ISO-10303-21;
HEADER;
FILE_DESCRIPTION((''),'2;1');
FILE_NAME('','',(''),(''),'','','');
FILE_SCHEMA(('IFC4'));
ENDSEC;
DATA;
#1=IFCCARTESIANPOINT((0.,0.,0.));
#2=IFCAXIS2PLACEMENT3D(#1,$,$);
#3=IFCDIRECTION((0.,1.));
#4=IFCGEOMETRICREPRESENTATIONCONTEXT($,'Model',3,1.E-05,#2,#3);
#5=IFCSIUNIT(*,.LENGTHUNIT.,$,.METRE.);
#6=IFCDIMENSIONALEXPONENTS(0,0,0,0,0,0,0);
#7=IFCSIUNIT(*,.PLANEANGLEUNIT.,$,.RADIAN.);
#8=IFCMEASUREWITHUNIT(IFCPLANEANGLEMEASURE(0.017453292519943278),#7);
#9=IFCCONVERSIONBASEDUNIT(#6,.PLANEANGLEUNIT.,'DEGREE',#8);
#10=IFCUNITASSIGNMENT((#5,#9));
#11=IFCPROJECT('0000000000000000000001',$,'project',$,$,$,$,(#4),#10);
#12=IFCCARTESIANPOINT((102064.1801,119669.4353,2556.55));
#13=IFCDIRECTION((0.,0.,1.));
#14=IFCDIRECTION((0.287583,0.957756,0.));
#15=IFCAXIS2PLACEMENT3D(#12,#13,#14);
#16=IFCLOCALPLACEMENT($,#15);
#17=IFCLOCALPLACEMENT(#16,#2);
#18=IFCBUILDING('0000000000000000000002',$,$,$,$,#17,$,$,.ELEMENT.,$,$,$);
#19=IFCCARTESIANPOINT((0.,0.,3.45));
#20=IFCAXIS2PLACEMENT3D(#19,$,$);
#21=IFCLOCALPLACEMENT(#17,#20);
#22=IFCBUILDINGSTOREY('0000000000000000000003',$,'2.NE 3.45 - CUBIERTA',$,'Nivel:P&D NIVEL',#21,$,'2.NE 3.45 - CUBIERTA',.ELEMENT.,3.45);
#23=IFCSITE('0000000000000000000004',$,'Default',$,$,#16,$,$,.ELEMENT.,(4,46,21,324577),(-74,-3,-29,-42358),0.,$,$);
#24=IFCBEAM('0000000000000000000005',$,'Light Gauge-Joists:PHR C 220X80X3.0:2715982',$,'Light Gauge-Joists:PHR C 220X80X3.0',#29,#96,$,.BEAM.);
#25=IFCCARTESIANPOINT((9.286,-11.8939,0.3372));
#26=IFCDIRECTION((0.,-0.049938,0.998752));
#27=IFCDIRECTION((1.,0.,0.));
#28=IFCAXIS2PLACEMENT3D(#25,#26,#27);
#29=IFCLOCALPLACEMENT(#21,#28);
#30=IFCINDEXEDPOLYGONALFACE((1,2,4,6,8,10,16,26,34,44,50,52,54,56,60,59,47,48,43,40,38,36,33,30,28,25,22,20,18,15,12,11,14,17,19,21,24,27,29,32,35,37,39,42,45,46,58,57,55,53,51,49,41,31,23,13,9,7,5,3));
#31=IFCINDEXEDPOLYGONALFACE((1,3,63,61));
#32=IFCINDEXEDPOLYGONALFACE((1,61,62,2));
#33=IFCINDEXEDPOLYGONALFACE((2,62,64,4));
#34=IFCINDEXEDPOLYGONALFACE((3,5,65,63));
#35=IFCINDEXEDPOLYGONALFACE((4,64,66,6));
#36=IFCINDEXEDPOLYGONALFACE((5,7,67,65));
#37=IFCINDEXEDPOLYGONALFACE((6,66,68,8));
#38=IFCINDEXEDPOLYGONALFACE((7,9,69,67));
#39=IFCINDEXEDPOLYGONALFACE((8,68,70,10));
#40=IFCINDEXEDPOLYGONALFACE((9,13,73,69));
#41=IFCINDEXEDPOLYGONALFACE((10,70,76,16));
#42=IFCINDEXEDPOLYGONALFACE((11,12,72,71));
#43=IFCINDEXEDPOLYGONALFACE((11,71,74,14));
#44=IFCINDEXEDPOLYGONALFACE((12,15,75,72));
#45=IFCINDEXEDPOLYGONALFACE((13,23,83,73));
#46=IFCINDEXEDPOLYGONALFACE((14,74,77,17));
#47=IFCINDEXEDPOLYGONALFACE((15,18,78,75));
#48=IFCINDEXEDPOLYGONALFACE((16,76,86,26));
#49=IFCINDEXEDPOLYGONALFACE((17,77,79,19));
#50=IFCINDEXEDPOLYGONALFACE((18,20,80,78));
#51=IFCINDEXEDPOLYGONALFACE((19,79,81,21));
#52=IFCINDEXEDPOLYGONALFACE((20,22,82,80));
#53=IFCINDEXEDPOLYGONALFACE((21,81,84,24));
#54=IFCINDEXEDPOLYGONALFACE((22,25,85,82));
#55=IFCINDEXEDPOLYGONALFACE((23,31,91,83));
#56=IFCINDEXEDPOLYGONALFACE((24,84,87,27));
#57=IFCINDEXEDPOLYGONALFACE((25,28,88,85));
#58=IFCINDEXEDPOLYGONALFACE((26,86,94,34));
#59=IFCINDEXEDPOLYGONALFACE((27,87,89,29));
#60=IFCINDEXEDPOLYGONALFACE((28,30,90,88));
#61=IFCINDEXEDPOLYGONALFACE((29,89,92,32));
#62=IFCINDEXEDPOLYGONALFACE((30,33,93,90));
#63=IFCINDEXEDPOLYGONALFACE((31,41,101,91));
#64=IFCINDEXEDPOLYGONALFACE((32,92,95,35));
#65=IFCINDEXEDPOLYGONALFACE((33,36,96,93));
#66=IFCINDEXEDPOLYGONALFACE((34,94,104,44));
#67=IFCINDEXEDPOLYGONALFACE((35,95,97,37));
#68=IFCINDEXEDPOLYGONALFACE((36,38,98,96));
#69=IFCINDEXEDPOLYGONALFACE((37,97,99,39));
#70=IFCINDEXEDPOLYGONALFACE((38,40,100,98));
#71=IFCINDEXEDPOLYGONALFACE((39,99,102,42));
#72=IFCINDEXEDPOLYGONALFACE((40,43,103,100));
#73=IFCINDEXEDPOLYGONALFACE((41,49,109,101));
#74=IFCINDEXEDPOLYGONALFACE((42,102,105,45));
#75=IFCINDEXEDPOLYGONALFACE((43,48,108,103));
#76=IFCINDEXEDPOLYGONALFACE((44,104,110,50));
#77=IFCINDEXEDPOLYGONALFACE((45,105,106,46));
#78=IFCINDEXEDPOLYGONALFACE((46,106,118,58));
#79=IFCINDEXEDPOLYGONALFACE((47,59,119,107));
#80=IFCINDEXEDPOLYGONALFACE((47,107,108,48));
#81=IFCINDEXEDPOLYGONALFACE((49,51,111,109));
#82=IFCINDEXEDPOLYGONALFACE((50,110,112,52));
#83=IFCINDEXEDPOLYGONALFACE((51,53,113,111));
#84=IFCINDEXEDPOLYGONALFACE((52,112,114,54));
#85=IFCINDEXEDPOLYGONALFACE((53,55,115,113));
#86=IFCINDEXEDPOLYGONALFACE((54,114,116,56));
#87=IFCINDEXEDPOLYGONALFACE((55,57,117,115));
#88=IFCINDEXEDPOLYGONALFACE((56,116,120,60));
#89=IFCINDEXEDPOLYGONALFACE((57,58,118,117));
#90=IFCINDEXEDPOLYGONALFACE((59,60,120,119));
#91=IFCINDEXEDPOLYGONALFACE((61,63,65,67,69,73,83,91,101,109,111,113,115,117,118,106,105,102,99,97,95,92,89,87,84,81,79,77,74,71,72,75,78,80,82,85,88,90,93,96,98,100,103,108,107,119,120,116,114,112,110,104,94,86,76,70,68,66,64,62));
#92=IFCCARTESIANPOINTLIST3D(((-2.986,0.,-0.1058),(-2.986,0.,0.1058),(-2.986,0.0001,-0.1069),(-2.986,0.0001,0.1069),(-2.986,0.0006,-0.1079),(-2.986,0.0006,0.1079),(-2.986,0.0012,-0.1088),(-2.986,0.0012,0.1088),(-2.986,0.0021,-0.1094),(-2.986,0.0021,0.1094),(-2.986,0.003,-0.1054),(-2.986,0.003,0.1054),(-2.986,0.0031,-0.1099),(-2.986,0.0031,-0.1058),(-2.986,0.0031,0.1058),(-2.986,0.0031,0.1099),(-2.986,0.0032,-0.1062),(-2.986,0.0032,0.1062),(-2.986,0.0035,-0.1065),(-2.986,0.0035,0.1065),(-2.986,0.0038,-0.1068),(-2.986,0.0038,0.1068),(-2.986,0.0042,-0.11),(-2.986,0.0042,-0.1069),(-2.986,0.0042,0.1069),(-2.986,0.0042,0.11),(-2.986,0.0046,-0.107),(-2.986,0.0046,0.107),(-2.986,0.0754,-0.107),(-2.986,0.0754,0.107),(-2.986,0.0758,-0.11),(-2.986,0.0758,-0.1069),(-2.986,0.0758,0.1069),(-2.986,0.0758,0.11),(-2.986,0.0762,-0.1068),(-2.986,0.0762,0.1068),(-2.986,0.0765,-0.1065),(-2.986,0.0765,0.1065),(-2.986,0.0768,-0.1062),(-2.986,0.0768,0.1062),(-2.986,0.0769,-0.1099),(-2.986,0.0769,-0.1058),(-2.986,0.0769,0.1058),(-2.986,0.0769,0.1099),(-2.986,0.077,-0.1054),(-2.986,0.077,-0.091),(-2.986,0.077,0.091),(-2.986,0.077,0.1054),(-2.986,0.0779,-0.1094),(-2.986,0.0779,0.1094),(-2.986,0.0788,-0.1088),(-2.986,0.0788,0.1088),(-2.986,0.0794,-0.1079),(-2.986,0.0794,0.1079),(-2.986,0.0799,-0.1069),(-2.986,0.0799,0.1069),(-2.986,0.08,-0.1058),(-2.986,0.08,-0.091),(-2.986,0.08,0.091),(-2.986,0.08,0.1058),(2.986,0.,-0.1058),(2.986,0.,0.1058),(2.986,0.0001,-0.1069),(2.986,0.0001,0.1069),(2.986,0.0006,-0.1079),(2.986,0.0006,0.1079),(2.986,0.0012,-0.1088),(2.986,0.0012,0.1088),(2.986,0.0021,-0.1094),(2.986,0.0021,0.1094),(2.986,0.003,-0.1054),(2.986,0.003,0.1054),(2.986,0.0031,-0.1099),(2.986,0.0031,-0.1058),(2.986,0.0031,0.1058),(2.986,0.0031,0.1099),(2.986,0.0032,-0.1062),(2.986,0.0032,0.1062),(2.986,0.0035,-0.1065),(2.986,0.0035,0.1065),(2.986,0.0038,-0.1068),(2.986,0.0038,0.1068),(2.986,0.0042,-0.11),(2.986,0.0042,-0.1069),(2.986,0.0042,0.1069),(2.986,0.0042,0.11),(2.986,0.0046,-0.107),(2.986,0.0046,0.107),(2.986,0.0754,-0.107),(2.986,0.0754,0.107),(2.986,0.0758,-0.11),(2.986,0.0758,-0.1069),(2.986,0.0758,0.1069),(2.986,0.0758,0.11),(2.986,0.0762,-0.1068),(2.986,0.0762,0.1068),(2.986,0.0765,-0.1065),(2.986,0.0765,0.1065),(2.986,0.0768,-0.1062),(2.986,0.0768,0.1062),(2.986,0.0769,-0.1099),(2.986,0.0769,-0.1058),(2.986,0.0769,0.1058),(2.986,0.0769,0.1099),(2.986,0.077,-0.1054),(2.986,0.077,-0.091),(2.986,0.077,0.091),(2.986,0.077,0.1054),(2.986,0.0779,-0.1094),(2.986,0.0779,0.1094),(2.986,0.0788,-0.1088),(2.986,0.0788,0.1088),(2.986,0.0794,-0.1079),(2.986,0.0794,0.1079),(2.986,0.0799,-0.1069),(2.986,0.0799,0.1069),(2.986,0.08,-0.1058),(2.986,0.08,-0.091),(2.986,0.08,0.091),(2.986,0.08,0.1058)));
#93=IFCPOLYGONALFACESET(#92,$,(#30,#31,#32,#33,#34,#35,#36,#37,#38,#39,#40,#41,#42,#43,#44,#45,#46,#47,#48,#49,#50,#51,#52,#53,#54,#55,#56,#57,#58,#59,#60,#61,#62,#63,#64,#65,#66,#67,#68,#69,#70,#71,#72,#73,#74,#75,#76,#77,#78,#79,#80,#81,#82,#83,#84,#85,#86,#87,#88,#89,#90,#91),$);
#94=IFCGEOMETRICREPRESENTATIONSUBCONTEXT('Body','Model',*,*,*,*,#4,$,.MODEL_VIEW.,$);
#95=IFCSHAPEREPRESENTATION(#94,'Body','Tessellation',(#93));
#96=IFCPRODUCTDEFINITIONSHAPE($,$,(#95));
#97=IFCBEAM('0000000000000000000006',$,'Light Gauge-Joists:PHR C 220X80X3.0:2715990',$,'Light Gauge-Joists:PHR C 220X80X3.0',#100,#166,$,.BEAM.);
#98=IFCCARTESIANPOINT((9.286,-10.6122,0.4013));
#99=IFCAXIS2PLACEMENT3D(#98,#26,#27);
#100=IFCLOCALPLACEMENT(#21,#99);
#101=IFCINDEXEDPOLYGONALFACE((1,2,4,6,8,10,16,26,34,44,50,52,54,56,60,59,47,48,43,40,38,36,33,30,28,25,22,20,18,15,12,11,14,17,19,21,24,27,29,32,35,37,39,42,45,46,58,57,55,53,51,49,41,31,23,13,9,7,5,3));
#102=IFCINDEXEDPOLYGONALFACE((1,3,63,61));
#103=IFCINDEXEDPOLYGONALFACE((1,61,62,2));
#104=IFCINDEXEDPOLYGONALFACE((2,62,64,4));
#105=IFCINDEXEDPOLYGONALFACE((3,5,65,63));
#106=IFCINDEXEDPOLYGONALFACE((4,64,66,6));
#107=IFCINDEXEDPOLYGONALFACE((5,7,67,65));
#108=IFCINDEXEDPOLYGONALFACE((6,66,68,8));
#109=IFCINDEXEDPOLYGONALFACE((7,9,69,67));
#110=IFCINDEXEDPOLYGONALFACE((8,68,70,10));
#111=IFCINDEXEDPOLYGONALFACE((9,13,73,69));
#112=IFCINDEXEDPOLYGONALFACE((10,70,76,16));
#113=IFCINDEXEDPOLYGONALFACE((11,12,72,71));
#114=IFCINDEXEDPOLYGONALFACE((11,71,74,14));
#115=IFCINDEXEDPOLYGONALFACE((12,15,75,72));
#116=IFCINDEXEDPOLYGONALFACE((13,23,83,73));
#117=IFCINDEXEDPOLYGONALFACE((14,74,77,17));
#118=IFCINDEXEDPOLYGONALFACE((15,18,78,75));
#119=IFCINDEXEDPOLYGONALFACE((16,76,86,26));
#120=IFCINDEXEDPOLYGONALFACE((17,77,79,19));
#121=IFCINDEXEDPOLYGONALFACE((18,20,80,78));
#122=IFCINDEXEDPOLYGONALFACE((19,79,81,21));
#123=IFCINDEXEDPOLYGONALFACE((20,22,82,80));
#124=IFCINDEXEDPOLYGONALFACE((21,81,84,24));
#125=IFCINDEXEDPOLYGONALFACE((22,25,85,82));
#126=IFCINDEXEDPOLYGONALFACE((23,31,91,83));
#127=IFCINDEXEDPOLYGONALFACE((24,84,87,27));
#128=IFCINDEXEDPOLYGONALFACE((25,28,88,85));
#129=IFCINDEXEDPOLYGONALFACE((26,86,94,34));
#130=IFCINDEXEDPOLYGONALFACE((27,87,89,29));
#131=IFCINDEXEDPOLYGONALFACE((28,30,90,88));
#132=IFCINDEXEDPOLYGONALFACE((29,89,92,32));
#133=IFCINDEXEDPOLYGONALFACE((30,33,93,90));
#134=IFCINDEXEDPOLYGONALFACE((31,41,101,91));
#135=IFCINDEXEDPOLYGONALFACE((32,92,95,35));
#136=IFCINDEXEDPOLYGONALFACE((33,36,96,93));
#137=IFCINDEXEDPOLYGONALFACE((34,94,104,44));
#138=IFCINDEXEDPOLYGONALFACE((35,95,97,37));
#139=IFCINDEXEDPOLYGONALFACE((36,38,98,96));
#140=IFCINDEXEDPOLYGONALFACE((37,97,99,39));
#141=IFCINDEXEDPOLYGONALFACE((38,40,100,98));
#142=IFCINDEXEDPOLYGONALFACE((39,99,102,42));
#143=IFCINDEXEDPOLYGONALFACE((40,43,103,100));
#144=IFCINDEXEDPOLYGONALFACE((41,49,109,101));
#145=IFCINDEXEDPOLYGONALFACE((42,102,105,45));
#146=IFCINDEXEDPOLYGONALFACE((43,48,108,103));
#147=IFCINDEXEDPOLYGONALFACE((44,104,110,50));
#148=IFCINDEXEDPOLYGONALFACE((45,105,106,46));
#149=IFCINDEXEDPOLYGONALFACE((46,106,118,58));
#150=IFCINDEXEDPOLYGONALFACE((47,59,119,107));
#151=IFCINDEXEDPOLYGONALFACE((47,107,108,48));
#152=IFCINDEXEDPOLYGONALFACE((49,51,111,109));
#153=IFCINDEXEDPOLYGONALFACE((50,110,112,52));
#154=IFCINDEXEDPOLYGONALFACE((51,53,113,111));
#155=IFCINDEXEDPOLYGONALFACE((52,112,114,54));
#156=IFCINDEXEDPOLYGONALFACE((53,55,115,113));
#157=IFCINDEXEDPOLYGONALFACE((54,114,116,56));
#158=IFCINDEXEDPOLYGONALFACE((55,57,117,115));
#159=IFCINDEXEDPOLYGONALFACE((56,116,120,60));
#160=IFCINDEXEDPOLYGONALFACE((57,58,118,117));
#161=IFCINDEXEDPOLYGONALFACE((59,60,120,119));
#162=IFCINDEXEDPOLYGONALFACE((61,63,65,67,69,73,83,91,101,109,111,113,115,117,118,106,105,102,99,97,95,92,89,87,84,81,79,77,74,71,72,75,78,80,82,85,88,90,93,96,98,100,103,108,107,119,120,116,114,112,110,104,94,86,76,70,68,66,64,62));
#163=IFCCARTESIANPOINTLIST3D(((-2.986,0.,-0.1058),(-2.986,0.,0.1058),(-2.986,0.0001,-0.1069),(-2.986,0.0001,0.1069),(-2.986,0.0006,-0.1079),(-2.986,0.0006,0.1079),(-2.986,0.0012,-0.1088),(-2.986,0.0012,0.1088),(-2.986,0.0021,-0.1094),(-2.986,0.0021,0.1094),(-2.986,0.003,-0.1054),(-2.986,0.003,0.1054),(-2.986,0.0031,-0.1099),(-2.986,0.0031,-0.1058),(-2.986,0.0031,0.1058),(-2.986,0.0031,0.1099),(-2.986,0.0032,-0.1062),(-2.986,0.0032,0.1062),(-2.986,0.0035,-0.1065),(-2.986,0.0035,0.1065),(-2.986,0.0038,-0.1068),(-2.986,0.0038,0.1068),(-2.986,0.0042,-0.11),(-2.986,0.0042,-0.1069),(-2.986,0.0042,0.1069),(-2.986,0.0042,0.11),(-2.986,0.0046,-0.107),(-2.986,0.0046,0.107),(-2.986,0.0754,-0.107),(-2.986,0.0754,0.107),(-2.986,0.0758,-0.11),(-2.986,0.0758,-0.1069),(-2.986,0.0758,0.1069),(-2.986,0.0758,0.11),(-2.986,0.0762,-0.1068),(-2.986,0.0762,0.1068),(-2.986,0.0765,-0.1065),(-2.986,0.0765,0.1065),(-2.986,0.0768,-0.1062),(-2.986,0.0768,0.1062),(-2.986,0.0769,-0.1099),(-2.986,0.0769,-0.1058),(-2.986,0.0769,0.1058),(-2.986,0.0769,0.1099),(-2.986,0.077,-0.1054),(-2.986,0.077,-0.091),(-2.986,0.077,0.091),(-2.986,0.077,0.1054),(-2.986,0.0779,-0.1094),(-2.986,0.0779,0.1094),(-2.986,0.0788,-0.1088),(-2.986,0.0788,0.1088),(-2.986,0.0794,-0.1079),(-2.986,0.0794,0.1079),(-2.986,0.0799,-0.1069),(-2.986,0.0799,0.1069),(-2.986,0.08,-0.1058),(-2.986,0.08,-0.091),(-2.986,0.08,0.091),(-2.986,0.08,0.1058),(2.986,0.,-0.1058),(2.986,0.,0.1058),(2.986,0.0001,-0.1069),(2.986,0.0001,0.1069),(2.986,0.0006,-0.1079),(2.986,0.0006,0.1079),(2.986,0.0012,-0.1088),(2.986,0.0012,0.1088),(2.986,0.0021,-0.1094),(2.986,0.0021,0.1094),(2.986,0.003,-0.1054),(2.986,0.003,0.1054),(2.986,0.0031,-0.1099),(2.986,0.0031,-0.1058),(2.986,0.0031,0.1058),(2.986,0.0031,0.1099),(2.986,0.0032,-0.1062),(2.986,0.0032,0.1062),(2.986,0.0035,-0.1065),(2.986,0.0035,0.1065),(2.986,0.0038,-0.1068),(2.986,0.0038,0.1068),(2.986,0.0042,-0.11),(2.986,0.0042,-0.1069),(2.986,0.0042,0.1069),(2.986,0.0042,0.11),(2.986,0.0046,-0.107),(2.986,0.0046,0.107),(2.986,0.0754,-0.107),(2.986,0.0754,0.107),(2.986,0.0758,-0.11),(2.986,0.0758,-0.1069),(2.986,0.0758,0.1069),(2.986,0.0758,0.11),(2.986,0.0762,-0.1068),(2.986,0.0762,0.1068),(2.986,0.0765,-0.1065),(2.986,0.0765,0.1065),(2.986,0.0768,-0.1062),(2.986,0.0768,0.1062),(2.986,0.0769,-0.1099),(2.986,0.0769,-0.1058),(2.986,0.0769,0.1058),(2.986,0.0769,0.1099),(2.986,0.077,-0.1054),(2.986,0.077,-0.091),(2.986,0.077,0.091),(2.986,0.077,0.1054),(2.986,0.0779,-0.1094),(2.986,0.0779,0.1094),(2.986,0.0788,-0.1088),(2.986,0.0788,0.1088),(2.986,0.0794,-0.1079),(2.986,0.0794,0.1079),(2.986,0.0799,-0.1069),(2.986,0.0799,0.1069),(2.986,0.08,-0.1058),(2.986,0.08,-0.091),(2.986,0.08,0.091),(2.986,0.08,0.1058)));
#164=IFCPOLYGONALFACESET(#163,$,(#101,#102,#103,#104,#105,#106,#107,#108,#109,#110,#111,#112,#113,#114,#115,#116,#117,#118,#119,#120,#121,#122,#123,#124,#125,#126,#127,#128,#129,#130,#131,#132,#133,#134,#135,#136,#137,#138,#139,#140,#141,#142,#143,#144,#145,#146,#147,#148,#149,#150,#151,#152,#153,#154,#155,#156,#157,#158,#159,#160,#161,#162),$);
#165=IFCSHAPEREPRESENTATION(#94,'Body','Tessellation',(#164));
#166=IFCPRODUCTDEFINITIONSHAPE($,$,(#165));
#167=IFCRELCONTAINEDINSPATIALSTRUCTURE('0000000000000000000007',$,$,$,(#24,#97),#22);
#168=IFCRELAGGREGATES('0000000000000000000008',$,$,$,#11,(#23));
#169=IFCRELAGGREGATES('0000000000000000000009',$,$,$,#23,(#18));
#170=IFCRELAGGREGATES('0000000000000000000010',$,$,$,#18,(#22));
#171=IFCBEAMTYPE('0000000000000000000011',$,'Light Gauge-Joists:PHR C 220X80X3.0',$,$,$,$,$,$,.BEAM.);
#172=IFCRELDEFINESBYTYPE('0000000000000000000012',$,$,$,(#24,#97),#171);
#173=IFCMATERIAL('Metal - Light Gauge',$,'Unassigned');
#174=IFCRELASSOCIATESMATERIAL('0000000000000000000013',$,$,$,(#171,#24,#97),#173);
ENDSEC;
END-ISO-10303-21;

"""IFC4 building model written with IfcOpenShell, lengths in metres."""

from ifc_helpers import new_model, entity, si_unit, converted_unit, direction, frame, origin, place, context, subcontext, project, spatial, line, arc, indexed_curve, outline, extrude, source, transform, mapped, material, type_object, type_shapes, element, save


model = new_model("IFC4")

# Units and contexts
model_context = context("Model", 3, precision=1e-05, world=origin(), true_north=direction((0.0, 1.0)))
body_context = subcontext(model_context, "Body", "Model", "MODEL_VIEW")
ifc_project = project(units=[si_unit("LENGTHUNIT", "METRE"), converted_unit("PLANEANGLEUNIT", "DEGREE", entity("IfcPlaneAngleMeasure", 0.017453292519943278), si_unit("PLANEANGLEUNIT", "RADIAN"), dimensions=[0, 0, 0, 0, 0, 0, 0])], contexts=[model_context])

# Site, building, storey
site_placement = place(None, frame((102064.1801, 119669.4353, 2556.55), z_axis=(0.0, 0.0, 1.0), x_axis=(0.287583, 0.957756, 0.0)))
site = spatial("IfcSite", under=ifc_project, at=site_placement, Name="Default", CompositionType="ELEMENT", RefLatitude=(4, 46, 21, 324577), RefLongitude=(-74, -3, -29, -42358), RefElevation=0.0)
building_placement = place(site_placement, origin())
building = spatial("IfcBuilding", under=site, at=building_placement, CompositionType="ELEMENT")
storey_placement = place(building_placement, frame((0.0, 0.0, 3.45)))
storey = spatial("IfcBuildingStorey", under=building, at=storey_placement, Name="2.NE 3.45 - CUBIERTA", ObjectType="Nivel:P&D NIVEL", LongName="2.NE 3.45 - CUBIERTA", CompositionType="ELEMENT", Elevation=3.45)

# Beams
ifc_material_1 = material(Name="Metal - Light Gauge", Category="Unassigned")
beam_type_1 = type_object("IfcBeamType", Name="Light Gauge-Joists:PHR C 220X80X3.0", PredefinedType="BEAM", material=ifc_material_1)
shared_shape_1 = source(origin(), body_context, "Body", "SweptSolid", [
    extrude(outline(indexed_curve([(-0.0477, -0.1058), (-0.0465, -0.1088), (-0.0435, -0.11), (0.0281, -0.11), (0.0311, -0.1088), (0.0323, -0.1058), (0.0323, -0.091), (0.0293, -0.091), (0.0293, -0.1054), (0.0288, -0.1065), (0.0277, -0.107), (-0.0431, -0.107), (-0.0442, -0.1065), (-0.0447, -0.1054), (-0.0447, 0.1054), (-0.0442, 0.1065), (-0.0431, 0.107), (0.0277, 0.107), (0.0288, 0.1065), (0.0293, 0.1054), (0.0293, 0.091), (0.0323, 0.091), (0.0323, 0.1058), (0.0311, 0.1088), (0.0281, 0.11), (-0.0435, 0.11), (-0.0465, 0.1088), (-0.0477, 0.1058)], segments=[arc(1, 2, 3), line(3, 4), arc(4, 5, 6), line(6, 7, 8, 9), arc(9, 10, 11), line(11, 12), arc(12, 13, 14), line(14, 15), arc(15, 16, 17), line(17, 18), arc(18, 19, 20), line(20, 21, 22, 23), arc(23, 24, 25), line(25, 26), arc(26, 27, 28), line(28, 1)], self_intersect=False)), frame((-2.986, 0.0477, 0.0), z_axis=(1.0, 0.0, 0.0), x_axis=(0.0, 1.0, 0.0)), (0.0, 0.0, 1.0), 5.972),
])
type_shapes(beam_type_1, [shared_shape_1])
for number, where, z_axis, x_axis, name in (
    (1, (9.286, -11.8939, 0.3372), (0.0, -0.049938, 0.998752), (1.0, 0.0, 0.0), "Light Gauge-Joists:PHR C 220X80X3.0:2715982"),
    (2, (9.286, -10.6122, 0.4013), (0.0, -0.049938, 0.998752), (1.0, 0.0, 0.0), "Light Gauge-Joists:PHR C 220X80X3.0:2715990"),
):
    element("IfcBeam", number, at=place(storey_placement, frame(where, z_axis=z_axis, x_axis=x_axis)), inside=storey, type_object=beam_type_1, material=ifc_material_1, Name=name, ObjectType="Light Gauge-Joists:PHR C 220X80X3.0", PredefinedType="BEAM", context=body_context, shape_type="MappedRepresentation", body=[
        mapped(shared_shape_1, transform((0.0, 0.0, 0.0), scale=1.0)),
    ])

save(model, "model.ifc")
